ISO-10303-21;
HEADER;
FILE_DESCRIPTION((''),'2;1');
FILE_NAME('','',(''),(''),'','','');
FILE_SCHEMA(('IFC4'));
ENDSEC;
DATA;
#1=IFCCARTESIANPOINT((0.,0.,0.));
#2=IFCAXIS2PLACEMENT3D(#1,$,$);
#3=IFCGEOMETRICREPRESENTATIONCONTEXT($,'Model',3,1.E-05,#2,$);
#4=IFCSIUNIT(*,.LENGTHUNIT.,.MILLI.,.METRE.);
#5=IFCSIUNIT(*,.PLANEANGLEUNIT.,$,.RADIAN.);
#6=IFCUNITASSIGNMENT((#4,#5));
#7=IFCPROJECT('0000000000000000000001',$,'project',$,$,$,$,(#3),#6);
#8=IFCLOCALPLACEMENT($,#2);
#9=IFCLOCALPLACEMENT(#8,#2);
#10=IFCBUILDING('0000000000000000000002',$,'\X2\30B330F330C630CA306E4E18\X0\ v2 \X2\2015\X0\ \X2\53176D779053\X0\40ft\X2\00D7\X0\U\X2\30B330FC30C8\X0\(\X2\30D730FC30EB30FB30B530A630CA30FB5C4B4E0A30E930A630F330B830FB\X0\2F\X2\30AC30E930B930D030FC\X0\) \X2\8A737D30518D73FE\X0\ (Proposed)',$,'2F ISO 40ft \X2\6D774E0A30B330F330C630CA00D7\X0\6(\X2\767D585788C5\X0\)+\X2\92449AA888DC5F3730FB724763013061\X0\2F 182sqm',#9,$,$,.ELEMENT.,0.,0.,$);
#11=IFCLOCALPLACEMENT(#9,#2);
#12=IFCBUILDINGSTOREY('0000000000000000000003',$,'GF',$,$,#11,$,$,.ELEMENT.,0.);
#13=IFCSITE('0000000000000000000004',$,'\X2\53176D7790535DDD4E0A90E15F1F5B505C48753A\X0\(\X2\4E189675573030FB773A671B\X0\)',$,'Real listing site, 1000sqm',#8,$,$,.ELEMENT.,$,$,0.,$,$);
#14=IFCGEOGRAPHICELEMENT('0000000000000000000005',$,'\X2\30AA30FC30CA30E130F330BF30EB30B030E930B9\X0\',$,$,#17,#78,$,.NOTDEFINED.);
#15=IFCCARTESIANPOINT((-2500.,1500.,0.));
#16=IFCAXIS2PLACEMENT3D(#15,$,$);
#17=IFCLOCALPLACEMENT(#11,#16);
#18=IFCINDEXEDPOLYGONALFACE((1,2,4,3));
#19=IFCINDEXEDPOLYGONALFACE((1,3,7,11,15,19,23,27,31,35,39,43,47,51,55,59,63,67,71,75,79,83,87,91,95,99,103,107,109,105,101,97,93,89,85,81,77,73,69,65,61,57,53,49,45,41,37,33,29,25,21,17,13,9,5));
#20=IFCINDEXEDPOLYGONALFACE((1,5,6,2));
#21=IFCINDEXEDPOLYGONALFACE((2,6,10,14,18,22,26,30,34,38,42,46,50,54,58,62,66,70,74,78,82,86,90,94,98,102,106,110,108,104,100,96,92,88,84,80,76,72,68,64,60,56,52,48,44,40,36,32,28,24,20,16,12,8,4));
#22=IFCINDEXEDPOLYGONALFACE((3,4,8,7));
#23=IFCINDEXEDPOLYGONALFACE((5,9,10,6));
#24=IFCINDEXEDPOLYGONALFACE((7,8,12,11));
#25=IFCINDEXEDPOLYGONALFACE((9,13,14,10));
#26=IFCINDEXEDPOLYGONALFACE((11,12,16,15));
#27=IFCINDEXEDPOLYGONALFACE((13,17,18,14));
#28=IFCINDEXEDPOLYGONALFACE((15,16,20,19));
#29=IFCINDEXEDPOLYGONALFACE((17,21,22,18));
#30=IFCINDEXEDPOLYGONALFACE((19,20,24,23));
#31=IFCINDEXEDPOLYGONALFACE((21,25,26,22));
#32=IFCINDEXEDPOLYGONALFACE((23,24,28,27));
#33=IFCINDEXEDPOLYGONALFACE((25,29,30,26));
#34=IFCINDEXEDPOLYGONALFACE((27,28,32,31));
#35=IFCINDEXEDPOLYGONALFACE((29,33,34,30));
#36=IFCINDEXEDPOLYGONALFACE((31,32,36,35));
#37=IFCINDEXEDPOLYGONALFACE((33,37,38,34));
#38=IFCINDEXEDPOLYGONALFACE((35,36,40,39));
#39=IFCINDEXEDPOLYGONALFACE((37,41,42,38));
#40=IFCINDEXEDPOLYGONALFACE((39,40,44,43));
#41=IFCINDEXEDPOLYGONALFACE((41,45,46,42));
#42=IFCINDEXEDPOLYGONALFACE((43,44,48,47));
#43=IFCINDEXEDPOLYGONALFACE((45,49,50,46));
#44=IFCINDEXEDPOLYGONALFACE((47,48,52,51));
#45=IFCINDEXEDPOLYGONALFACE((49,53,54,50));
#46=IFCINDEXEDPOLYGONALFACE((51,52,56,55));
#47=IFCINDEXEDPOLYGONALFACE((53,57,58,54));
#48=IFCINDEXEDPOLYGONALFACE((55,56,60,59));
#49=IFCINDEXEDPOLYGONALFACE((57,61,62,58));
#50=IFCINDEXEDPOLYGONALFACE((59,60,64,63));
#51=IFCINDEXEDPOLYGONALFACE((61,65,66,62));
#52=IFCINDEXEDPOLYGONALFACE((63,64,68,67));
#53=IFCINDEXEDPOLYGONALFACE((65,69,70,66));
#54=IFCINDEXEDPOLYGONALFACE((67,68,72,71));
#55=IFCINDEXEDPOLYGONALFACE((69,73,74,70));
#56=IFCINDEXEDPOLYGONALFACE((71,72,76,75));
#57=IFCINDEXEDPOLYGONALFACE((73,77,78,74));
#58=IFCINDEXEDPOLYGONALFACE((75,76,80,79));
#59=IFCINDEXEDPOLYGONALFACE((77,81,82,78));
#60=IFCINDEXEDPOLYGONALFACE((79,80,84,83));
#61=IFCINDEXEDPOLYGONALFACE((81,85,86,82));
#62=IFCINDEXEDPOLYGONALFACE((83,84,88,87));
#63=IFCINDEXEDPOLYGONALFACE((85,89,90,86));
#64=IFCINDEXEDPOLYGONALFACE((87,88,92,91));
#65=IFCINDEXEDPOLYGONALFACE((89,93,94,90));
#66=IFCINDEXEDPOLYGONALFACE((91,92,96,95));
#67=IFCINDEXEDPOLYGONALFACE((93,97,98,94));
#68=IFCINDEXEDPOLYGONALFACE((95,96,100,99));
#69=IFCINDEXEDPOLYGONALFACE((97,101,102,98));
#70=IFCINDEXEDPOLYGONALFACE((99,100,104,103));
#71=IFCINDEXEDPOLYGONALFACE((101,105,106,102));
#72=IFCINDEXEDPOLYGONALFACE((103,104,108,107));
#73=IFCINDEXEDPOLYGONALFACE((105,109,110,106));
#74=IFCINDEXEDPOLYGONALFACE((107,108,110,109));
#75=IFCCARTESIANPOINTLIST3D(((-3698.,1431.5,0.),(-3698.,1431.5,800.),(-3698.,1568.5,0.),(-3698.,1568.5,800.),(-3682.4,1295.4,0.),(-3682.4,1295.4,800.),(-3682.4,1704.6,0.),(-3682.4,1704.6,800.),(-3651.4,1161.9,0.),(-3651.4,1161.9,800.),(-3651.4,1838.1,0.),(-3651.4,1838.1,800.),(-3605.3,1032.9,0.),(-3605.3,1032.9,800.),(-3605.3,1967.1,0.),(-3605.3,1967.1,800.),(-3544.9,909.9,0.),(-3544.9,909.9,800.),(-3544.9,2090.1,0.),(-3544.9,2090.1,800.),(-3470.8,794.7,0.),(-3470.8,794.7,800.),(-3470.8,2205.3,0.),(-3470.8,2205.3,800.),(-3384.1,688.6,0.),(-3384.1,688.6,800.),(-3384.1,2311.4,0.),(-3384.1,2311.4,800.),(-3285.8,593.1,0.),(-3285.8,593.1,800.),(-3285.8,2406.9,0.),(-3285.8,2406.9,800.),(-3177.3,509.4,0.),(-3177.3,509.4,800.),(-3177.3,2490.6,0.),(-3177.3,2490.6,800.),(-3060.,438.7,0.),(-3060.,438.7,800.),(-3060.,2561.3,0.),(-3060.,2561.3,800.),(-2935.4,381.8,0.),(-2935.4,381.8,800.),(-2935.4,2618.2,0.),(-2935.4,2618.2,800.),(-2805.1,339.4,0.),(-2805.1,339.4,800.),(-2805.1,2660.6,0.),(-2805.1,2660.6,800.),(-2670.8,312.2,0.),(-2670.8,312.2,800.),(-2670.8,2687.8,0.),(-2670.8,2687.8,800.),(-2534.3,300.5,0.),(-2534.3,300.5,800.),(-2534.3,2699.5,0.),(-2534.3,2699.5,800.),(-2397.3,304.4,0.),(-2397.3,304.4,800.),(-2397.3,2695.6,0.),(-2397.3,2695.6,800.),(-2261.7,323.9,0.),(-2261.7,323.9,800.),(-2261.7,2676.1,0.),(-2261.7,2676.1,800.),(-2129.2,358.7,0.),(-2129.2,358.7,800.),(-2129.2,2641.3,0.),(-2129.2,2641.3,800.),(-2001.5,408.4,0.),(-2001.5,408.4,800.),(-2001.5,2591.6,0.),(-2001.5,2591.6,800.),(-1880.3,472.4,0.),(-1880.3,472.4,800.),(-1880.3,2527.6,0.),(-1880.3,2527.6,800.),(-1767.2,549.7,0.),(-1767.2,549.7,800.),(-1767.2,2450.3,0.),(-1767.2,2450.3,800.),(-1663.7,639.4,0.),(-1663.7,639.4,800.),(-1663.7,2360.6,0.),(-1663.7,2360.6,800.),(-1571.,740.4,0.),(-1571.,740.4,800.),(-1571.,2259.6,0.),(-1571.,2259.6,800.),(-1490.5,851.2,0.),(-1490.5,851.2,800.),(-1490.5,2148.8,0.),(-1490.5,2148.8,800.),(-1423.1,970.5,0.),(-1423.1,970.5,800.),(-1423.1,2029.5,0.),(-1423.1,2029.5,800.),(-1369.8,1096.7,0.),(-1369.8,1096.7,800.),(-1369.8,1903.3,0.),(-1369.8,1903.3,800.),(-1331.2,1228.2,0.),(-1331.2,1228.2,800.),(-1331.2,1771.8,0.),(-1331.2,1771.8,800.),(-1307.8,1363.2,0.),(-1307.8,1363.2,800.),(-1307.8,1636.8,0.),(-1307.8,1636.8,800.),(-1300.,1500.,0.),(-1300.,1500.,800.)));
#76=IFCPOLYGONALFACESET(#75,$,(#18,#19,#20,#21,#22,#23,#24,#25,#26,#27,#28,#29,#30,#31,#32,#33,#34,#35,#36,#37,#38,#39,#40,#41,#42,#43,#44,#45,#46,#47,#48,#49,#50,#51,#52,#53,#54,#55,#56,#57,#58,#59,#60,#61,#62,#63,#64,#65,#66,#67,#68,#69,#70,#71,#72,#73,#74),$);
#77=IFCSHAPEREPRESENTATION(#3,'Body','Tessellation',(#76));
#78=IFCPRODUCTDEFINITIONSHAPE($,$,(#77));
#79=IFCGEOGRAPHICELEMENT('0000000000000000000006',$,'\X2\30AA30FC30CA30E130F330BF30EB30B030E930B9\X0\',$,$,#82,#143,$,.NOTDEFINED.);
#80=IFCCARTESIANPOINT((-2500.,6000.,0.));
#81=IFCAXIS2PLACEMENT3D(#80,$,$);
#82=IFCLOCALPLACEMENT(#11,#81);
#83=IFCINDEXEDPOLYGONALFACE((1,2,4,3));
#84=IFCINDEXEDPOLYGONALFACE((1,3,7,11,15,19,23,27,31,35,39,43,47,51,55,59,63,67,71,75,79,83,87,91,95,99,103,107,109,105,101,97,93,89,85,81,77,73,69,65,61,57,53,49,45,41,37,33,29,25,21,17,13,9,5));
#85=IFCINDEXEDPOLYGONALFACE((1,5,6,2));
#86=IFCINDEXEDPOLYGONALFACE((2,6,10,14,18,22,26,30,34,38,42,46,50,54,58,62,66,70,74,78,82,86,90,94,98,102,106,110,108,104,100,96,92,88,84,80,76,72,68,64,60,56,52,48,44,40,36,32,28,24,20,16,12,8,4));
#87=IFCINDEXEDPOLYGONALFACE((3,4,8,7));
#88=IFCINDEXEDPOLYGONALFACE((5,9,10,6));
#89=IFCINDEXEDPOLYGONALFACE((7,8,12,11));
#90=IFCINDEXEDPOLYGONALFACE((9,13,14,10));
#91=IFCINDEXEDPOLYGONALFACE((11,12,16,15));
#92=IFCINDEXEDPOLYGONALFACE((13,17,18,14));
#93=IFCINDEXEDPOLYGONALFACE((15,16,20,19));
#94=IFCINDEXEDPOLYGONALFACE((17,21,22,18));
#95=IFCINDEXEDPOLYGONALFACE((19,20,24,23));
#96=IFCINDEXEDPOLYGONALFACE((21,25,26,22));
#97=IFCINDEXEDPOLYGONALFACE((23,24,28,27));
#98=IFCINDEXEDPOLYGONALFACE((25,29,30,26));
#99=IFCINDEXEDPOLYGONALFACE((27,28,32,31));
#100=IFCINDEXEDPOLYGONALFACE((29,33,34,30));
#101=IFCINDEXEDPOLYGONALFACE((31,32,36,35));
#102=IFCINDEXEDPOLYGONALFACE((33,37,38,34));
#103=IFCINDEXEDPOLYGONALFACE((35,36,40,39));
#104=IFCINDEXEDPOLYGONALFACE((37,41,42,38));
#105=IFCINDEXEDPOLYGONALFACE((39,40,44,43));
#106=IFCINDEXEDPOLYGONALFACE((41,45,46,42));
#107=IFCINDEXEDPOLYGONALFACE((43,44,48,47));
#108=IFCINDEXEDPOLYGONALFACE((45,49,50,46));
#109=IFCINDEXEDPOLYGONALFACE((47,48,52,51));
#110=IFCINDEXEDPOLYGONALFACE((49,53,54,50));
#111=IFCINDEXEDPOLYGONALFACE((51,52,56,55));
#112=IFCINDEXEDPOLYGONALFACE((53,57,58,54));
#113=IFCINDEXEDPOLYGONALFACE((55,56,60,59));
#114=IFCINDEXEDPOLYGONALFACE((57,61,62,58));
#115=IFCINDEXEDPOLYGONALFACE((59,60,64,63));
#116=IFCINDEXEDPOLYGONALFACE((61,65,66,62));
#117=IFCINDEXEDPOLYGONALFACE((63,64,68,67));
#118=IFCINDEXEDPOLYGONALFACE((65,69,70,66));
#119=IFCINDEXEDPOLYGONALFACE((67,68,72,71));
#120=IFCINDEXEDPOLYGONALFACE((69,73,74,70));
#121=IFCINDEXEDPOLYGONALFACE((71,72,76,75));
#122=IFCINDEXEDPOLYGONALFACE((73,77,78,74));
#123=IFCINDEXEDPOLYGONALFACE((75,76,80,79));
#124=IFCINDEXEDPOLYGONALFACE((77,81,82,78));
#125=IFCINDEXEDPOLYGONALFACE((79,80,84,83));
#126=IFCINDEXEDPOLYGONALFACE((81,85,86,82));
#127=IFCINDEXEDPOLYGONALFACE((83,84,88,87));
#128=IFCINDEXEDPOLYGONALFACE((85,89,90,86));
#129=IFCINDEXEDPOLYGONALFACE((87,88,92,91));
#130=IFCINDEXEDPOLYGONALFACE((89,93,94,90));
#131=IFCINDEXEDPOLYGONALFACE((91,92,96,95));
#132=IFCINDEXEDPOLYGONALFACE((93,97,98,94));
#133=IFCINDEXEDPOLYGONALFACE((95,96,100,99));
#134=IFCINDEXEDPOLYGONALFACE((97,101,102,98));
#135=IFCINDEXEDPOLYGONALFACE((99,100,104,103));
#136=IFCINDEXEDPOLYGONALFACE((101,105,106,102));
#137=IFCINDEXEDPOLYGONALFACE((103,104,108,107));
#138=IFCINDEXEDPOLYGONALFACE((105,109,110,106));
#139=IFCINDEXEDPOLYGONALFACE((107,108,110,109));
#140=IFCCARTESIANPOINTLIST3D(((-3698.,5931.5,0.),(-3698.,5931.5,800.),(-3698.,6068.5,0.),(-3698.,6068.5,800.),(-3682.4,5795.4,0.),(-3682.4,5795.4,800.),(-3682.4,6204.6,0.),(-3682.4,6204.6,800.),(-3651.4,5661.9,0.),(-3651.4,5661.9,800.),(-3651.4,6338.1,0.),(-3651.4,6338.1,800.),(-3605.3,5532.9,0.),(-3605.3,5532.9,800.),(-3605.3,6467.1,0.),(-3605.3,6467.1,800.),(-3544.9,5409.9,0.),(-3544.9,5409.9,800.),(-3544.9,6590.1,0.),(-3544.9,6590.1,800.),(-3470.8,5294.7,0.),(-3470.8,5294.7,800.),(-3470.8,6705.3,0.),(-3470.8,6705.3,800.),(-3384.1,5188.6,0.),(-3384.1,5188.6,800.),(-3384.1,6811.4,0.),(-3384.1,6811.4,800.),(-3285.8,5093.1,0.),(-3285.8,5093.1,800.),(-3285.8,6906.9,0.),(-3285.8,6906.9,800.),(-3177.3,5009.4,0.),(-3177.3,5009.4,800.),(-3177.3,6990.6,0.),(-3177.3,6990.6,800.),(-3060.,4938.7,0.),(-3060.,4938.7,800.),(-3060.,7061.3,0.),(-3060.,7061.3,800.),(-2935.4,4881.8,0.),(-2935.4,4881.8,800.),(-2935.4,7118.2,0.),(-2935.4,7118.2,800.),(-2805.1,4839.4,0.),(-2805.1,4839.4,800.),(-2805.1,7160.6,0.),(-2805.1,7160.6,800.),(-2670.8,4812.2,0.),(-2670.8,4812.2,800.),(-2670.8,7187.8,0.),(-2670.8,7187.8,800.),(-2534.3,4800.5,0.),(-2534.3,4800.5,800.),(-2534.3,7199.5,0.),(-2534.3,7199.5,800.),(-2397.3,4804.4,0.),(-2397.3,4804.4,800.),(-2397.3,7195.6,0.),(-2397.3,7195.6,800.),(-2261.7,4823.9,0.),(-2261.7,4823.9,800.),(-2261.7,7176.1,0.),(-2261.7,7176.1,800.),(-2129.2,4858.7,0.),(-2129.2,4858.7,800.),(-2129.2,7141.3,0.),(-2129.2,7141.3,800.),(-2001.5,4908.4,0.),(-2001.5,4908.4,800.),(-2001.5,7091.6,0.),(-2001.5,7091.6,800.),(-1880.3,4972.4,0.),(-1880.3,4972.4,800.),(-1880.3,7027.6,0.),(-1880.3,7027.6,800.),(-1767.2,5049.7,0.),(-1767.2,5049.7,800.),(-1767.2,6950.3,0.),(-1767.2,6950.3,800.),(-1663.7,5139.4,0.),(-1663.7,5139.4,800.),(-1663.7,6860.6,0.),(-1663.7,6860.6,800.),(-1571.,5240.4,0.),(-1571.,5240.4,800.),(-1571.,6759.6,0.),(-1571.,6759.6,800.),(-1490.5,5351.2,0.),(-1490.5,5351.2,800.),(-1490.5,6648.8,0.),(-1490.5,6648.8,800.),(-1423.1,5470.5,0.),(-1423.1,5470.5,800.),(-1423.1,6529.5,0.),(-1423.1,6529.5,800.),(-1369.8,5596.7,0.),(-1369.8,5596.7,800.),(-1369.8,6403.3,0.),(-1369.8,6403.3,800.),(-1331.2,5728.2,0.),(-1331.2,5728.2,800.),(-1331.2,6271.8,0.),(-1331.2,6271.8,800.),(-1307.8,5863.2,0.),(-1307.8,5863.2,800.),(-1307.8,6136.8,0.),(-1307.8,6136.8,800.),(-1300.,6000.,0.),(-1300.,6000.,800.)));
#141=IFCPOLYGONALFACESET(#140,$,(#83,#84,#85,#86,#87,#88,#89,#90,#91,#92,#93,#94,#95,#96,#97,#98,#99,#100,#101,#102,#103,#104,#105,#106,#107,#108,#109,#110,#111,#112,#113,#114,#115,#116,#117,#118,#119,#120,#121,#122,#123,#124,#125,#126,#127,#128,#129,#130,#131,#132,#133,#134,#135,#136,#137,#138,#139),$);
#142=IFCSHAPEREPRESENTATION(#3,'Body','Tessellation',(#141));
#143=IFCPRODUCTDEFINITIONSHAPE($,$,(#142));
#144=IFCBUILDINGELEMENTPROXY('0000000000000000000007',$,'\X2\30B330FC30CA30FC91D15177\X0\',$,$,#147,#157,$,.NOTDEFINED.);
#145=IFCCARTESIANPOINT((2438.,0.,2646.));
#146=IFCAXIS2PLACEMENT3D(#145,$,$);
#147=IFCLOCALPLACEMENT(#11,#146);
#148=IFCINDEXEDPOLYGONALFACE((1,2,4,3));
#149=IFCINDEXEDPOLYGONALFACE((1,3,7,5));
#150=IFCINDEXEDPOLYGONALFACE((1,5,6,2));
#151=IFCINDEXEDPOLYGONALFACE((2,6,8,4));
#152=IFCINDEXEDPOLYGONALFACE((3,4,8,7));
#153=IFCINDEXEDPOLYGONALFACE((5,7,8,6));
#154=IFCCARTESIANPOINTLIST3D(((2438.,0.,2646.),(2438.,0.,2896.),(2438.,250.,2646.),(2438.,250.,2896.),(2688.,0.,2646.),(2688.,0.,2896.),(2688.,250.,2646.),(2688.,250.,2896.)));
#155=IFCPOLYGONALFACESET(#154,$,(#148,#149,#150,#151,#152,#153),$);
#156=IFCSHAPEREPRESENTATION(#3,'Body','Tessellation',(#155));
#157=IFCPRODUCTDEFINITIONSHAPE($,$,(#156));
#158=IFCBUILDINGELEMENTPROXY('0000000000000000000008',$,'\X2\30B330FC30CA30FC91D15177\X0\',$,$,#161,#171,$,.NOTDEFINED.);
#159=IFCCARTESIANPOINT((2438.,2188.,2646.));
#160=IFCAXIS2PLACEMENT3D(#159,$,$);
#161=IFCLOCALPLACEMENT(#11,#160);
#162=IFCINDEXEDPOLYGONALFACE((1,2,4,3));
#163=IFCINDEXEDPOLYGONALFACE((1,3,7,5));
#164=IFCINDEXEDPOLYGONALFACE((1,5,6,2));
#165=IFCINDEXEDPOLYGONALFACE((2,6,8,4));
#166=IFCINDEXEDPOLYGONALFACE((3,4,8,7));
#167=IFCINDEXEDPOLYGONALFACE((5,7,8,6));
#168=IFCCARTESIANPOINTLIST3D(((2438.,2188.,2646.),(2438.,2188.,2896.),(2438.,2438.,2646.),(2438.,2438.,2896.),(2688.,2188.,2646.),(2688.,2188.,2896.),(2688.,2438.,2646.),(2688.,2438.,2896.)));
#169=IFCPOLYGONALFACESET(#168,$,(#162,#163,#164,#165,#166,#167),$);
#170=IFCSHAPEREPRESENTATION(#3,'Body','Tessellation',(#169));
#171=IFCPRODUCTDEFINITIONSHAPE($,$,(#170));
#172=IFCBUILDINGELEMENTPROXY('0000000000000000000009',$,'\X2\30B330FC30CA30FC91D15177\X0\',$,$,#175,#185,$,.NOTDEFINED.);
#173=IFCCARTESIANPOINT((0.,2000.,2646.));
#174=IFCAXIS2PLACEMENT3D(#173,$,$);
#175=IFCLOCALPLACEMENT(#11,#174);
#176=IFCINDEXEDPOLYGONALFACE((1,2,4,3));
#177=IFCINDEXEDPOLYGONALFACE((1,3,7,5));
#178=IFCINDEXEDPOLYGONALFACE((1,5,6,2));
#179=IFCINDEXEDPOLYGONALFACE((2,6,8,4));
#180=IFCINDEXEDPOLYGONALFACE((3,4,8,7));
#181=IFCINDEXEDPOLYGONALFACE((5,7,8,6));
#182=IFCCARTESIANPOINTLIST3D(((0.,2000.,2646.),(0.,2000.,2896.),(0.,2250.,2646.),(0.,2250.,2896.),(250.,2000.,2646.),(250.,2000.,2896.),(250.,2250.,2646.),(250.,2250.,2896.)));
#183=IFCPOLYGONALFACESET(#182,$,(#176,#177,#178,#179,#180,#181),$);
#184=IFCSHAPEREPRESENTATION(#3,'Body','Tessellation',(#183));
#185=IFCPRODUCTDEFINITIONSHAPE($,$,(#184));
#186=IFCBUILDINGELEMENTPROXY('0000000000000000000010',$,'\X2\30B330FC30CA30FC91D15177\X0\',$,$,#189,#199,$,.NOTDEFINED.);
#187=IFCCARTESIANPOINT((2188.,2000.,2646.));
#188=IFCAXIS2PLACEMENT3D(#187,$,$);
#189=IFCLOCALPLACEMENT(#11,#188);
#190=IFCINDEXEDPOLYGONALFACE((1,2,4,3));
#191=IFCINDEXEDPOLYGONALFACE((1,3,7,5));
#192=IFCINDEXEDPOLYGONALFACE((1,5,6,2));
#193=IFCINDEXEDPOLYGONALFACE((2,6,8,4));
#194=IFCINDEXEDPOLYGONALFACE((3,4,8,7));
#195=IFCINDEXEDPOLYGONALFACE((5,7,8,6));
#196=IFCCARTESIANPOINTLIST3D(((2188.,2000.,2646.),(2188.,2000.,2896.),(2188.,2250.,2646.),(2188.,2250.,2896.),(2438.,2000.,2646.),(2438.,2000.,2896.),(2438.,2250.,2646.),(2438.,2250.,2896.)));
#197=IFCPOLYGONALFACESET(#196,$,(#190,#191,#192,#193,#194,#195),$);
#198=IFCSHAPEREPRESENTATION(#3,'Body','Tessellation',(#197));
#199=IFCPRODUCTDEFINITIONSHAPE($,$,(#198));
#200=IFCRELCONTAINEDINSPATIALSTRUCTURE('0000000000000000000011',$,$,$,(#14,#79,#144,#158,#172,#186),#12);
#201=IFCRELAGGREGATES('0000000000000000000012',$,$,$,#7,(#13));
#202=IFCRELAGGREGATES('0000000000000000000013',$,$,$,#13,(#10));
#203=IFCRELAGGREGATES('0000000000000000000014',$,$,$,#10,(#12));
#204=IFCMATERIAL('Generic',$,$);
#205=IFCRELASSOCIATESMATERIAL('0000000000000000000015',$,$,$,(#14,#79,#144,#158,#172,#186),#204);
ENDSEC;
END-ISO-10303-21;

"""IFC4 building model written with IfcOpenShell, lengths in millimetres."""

from ifc_helpers import new_model, si_unit, frame, frame_2d, origin, origin_2d, place, context, project, spatial, rectangle, circle, extrude, material, element, save


model = new_model("IFC4")

# Units and contexts
model_context = context("Model", 3, precision=1e-05, world=origin())
ifc_project = project(units=[si_unit("LENGTHUNIT", "METRE", prefix="MILLI"), si_unit("PLANEANGLEUNIT", "RADIAN")], contexts=[model_context])

# Site, building, storey
site_placement = place(None, origin())
site = spatial("IfcSite", under=ifc_project, at=site_placement, Name="北海道川上郡弟子屈町(丘陵地・眺望)", ObjectType="Real listing site, 1000sqm", CompositionType="ELEMENT", RefElevation=0.0)
building_placement = place(site_placement, origin())
building = spatial("IfcBuilding", under=site, at=building_placement, Name="コンテナの丘 v2 ― 北海道40ft×Uコート(プール・サウナ・屋上ラウンジ・2Fガラスバー) 詳細再現 (Proposed)", ObjectType="2F ISO 40ft 海上コンテナ×6(白塗装)+鉄骨補強・片持ち2F 182sqm", CompositionType="ELEMENT", ElevationOfRefHeight=0.0, ElevationOfTerrain=0.0)
storey_placement = place(building_placement, origin())
storey = spatial("IfcBuildingStorey", under=building, at=storey_placement, Name="GF", CompositionType="ELEMENT", Elevation=0.0)

# Shared definitions
ifc_material = material(Name="Generic")

# Geographic elements
geographic_element_1_placement = place(storey_placement, frame((-2500.0, 1500.0, 0.0)))
element("IfcGeographicElement", 1, at=geographic_element_1_placement, inside=storey, material=ifc_material, Name="オーナメンタルグラス", PredefinedType="NOTDEFINED", context=model_context, shape_type="SweptSolid", body=[
    extrude(circle(Radius=1200.0, at=origin_2d()), frame((-2500.0, 1500.0, 0.0)), (0.0, 0.0, 1.0), 800.0),
])
geographic_element_2_placement = place(storey_placement, frame((-2500.0, 6000.0, 0.0)))
element("IfcGeographicElement", 2, at=geographic_element_2_placement, inside=storey, material=ifc_material, Name="オーナメンタルグラス", PredefinedType="NOTDEFINED", context=model_context, shape_type="SweptSolid", body=[
    extrude(circle(Radius=1200.0, at=origin_2d()), frame((-2500.0, 6000.0, 0.0)), (0.0, 0.0, 1.0), 800.0),
])

# Building element proxies
proxy_1_placement = place(storey_placement, frame((2438.0, 0.0, 2646.0)))
element("IfcBuildingElementProxy", 3, at=proxy_1_placement, inside=storey, material=ifc_material, Name="コーナー金具", PredefinedType="NOTDEFINED", context=model_context, shape_type="SweptSolid", body=[
    extrude(rectangle(XDim=250.0, YDim=250.0, at=frame_2d((125.0, 125.0))), frame((2438.0, 0.0, 2646.0)), (0.0, 0.0, 1.0), 250.0),
])
proxy_2_placement = place(storey_placement, frame((2438.0, 2188.0, 2646.0)))
element("IfcBuildingElementProxy", 4, at=proxy_2_placement, inside=storey, material=ifc_material, Name="コーナー金具", PredefinedType="NOTDEFINED", context=model_context, shape_type="SweptSolid", body=[
    extrude(rectangle(XDim=250.0, YDim=250.0, at=frame_2d((125.0, 125.0))), frame((2438.0, 2188.0, 2646.0)), (0.0, 0.0, 1.0), 250.0),
])
proxy_3_placement = place(storey_placement, frame((0.0, 2000.0, 2646.0)))
element("IfcBuildingElementProxy", 5, at=proxy_3_placement, inside=storey, material=ifc_material, Name="コーナー金具", PredefinedType="NOTDEFINED", context=model_context, shape_type="SweptSolid", body=[
    extrude(rectangle(XDim=250.0, YDim=250.0, at=frame_2d((125.0, 125.0))), frame((0.0, 2000.0, 2646.0)), (0.0, 0.0, 1.0), 250.0),
])
proxy_4_placement = place(storey_placement, frame((2188.0, 2000.0, 2646.0)))
element("IfcBuildingElementProxy", 6, at=proxy_4_placement, inside=storey, material=ifc_material, Name="コーナー金具", PredefinedType="NOTDEFINED", context=model_context, shape_type="SweptSolid", body=[
    extrude(rectangle(XDim=250.0, YDim=250.0, at=frame_2d((125.0, 125.0))), frame((2188.0, 2000.0, 2646.0)), (0.0, 0.0, 1.0), 250.0),
])

save(model, "model.ifc")
